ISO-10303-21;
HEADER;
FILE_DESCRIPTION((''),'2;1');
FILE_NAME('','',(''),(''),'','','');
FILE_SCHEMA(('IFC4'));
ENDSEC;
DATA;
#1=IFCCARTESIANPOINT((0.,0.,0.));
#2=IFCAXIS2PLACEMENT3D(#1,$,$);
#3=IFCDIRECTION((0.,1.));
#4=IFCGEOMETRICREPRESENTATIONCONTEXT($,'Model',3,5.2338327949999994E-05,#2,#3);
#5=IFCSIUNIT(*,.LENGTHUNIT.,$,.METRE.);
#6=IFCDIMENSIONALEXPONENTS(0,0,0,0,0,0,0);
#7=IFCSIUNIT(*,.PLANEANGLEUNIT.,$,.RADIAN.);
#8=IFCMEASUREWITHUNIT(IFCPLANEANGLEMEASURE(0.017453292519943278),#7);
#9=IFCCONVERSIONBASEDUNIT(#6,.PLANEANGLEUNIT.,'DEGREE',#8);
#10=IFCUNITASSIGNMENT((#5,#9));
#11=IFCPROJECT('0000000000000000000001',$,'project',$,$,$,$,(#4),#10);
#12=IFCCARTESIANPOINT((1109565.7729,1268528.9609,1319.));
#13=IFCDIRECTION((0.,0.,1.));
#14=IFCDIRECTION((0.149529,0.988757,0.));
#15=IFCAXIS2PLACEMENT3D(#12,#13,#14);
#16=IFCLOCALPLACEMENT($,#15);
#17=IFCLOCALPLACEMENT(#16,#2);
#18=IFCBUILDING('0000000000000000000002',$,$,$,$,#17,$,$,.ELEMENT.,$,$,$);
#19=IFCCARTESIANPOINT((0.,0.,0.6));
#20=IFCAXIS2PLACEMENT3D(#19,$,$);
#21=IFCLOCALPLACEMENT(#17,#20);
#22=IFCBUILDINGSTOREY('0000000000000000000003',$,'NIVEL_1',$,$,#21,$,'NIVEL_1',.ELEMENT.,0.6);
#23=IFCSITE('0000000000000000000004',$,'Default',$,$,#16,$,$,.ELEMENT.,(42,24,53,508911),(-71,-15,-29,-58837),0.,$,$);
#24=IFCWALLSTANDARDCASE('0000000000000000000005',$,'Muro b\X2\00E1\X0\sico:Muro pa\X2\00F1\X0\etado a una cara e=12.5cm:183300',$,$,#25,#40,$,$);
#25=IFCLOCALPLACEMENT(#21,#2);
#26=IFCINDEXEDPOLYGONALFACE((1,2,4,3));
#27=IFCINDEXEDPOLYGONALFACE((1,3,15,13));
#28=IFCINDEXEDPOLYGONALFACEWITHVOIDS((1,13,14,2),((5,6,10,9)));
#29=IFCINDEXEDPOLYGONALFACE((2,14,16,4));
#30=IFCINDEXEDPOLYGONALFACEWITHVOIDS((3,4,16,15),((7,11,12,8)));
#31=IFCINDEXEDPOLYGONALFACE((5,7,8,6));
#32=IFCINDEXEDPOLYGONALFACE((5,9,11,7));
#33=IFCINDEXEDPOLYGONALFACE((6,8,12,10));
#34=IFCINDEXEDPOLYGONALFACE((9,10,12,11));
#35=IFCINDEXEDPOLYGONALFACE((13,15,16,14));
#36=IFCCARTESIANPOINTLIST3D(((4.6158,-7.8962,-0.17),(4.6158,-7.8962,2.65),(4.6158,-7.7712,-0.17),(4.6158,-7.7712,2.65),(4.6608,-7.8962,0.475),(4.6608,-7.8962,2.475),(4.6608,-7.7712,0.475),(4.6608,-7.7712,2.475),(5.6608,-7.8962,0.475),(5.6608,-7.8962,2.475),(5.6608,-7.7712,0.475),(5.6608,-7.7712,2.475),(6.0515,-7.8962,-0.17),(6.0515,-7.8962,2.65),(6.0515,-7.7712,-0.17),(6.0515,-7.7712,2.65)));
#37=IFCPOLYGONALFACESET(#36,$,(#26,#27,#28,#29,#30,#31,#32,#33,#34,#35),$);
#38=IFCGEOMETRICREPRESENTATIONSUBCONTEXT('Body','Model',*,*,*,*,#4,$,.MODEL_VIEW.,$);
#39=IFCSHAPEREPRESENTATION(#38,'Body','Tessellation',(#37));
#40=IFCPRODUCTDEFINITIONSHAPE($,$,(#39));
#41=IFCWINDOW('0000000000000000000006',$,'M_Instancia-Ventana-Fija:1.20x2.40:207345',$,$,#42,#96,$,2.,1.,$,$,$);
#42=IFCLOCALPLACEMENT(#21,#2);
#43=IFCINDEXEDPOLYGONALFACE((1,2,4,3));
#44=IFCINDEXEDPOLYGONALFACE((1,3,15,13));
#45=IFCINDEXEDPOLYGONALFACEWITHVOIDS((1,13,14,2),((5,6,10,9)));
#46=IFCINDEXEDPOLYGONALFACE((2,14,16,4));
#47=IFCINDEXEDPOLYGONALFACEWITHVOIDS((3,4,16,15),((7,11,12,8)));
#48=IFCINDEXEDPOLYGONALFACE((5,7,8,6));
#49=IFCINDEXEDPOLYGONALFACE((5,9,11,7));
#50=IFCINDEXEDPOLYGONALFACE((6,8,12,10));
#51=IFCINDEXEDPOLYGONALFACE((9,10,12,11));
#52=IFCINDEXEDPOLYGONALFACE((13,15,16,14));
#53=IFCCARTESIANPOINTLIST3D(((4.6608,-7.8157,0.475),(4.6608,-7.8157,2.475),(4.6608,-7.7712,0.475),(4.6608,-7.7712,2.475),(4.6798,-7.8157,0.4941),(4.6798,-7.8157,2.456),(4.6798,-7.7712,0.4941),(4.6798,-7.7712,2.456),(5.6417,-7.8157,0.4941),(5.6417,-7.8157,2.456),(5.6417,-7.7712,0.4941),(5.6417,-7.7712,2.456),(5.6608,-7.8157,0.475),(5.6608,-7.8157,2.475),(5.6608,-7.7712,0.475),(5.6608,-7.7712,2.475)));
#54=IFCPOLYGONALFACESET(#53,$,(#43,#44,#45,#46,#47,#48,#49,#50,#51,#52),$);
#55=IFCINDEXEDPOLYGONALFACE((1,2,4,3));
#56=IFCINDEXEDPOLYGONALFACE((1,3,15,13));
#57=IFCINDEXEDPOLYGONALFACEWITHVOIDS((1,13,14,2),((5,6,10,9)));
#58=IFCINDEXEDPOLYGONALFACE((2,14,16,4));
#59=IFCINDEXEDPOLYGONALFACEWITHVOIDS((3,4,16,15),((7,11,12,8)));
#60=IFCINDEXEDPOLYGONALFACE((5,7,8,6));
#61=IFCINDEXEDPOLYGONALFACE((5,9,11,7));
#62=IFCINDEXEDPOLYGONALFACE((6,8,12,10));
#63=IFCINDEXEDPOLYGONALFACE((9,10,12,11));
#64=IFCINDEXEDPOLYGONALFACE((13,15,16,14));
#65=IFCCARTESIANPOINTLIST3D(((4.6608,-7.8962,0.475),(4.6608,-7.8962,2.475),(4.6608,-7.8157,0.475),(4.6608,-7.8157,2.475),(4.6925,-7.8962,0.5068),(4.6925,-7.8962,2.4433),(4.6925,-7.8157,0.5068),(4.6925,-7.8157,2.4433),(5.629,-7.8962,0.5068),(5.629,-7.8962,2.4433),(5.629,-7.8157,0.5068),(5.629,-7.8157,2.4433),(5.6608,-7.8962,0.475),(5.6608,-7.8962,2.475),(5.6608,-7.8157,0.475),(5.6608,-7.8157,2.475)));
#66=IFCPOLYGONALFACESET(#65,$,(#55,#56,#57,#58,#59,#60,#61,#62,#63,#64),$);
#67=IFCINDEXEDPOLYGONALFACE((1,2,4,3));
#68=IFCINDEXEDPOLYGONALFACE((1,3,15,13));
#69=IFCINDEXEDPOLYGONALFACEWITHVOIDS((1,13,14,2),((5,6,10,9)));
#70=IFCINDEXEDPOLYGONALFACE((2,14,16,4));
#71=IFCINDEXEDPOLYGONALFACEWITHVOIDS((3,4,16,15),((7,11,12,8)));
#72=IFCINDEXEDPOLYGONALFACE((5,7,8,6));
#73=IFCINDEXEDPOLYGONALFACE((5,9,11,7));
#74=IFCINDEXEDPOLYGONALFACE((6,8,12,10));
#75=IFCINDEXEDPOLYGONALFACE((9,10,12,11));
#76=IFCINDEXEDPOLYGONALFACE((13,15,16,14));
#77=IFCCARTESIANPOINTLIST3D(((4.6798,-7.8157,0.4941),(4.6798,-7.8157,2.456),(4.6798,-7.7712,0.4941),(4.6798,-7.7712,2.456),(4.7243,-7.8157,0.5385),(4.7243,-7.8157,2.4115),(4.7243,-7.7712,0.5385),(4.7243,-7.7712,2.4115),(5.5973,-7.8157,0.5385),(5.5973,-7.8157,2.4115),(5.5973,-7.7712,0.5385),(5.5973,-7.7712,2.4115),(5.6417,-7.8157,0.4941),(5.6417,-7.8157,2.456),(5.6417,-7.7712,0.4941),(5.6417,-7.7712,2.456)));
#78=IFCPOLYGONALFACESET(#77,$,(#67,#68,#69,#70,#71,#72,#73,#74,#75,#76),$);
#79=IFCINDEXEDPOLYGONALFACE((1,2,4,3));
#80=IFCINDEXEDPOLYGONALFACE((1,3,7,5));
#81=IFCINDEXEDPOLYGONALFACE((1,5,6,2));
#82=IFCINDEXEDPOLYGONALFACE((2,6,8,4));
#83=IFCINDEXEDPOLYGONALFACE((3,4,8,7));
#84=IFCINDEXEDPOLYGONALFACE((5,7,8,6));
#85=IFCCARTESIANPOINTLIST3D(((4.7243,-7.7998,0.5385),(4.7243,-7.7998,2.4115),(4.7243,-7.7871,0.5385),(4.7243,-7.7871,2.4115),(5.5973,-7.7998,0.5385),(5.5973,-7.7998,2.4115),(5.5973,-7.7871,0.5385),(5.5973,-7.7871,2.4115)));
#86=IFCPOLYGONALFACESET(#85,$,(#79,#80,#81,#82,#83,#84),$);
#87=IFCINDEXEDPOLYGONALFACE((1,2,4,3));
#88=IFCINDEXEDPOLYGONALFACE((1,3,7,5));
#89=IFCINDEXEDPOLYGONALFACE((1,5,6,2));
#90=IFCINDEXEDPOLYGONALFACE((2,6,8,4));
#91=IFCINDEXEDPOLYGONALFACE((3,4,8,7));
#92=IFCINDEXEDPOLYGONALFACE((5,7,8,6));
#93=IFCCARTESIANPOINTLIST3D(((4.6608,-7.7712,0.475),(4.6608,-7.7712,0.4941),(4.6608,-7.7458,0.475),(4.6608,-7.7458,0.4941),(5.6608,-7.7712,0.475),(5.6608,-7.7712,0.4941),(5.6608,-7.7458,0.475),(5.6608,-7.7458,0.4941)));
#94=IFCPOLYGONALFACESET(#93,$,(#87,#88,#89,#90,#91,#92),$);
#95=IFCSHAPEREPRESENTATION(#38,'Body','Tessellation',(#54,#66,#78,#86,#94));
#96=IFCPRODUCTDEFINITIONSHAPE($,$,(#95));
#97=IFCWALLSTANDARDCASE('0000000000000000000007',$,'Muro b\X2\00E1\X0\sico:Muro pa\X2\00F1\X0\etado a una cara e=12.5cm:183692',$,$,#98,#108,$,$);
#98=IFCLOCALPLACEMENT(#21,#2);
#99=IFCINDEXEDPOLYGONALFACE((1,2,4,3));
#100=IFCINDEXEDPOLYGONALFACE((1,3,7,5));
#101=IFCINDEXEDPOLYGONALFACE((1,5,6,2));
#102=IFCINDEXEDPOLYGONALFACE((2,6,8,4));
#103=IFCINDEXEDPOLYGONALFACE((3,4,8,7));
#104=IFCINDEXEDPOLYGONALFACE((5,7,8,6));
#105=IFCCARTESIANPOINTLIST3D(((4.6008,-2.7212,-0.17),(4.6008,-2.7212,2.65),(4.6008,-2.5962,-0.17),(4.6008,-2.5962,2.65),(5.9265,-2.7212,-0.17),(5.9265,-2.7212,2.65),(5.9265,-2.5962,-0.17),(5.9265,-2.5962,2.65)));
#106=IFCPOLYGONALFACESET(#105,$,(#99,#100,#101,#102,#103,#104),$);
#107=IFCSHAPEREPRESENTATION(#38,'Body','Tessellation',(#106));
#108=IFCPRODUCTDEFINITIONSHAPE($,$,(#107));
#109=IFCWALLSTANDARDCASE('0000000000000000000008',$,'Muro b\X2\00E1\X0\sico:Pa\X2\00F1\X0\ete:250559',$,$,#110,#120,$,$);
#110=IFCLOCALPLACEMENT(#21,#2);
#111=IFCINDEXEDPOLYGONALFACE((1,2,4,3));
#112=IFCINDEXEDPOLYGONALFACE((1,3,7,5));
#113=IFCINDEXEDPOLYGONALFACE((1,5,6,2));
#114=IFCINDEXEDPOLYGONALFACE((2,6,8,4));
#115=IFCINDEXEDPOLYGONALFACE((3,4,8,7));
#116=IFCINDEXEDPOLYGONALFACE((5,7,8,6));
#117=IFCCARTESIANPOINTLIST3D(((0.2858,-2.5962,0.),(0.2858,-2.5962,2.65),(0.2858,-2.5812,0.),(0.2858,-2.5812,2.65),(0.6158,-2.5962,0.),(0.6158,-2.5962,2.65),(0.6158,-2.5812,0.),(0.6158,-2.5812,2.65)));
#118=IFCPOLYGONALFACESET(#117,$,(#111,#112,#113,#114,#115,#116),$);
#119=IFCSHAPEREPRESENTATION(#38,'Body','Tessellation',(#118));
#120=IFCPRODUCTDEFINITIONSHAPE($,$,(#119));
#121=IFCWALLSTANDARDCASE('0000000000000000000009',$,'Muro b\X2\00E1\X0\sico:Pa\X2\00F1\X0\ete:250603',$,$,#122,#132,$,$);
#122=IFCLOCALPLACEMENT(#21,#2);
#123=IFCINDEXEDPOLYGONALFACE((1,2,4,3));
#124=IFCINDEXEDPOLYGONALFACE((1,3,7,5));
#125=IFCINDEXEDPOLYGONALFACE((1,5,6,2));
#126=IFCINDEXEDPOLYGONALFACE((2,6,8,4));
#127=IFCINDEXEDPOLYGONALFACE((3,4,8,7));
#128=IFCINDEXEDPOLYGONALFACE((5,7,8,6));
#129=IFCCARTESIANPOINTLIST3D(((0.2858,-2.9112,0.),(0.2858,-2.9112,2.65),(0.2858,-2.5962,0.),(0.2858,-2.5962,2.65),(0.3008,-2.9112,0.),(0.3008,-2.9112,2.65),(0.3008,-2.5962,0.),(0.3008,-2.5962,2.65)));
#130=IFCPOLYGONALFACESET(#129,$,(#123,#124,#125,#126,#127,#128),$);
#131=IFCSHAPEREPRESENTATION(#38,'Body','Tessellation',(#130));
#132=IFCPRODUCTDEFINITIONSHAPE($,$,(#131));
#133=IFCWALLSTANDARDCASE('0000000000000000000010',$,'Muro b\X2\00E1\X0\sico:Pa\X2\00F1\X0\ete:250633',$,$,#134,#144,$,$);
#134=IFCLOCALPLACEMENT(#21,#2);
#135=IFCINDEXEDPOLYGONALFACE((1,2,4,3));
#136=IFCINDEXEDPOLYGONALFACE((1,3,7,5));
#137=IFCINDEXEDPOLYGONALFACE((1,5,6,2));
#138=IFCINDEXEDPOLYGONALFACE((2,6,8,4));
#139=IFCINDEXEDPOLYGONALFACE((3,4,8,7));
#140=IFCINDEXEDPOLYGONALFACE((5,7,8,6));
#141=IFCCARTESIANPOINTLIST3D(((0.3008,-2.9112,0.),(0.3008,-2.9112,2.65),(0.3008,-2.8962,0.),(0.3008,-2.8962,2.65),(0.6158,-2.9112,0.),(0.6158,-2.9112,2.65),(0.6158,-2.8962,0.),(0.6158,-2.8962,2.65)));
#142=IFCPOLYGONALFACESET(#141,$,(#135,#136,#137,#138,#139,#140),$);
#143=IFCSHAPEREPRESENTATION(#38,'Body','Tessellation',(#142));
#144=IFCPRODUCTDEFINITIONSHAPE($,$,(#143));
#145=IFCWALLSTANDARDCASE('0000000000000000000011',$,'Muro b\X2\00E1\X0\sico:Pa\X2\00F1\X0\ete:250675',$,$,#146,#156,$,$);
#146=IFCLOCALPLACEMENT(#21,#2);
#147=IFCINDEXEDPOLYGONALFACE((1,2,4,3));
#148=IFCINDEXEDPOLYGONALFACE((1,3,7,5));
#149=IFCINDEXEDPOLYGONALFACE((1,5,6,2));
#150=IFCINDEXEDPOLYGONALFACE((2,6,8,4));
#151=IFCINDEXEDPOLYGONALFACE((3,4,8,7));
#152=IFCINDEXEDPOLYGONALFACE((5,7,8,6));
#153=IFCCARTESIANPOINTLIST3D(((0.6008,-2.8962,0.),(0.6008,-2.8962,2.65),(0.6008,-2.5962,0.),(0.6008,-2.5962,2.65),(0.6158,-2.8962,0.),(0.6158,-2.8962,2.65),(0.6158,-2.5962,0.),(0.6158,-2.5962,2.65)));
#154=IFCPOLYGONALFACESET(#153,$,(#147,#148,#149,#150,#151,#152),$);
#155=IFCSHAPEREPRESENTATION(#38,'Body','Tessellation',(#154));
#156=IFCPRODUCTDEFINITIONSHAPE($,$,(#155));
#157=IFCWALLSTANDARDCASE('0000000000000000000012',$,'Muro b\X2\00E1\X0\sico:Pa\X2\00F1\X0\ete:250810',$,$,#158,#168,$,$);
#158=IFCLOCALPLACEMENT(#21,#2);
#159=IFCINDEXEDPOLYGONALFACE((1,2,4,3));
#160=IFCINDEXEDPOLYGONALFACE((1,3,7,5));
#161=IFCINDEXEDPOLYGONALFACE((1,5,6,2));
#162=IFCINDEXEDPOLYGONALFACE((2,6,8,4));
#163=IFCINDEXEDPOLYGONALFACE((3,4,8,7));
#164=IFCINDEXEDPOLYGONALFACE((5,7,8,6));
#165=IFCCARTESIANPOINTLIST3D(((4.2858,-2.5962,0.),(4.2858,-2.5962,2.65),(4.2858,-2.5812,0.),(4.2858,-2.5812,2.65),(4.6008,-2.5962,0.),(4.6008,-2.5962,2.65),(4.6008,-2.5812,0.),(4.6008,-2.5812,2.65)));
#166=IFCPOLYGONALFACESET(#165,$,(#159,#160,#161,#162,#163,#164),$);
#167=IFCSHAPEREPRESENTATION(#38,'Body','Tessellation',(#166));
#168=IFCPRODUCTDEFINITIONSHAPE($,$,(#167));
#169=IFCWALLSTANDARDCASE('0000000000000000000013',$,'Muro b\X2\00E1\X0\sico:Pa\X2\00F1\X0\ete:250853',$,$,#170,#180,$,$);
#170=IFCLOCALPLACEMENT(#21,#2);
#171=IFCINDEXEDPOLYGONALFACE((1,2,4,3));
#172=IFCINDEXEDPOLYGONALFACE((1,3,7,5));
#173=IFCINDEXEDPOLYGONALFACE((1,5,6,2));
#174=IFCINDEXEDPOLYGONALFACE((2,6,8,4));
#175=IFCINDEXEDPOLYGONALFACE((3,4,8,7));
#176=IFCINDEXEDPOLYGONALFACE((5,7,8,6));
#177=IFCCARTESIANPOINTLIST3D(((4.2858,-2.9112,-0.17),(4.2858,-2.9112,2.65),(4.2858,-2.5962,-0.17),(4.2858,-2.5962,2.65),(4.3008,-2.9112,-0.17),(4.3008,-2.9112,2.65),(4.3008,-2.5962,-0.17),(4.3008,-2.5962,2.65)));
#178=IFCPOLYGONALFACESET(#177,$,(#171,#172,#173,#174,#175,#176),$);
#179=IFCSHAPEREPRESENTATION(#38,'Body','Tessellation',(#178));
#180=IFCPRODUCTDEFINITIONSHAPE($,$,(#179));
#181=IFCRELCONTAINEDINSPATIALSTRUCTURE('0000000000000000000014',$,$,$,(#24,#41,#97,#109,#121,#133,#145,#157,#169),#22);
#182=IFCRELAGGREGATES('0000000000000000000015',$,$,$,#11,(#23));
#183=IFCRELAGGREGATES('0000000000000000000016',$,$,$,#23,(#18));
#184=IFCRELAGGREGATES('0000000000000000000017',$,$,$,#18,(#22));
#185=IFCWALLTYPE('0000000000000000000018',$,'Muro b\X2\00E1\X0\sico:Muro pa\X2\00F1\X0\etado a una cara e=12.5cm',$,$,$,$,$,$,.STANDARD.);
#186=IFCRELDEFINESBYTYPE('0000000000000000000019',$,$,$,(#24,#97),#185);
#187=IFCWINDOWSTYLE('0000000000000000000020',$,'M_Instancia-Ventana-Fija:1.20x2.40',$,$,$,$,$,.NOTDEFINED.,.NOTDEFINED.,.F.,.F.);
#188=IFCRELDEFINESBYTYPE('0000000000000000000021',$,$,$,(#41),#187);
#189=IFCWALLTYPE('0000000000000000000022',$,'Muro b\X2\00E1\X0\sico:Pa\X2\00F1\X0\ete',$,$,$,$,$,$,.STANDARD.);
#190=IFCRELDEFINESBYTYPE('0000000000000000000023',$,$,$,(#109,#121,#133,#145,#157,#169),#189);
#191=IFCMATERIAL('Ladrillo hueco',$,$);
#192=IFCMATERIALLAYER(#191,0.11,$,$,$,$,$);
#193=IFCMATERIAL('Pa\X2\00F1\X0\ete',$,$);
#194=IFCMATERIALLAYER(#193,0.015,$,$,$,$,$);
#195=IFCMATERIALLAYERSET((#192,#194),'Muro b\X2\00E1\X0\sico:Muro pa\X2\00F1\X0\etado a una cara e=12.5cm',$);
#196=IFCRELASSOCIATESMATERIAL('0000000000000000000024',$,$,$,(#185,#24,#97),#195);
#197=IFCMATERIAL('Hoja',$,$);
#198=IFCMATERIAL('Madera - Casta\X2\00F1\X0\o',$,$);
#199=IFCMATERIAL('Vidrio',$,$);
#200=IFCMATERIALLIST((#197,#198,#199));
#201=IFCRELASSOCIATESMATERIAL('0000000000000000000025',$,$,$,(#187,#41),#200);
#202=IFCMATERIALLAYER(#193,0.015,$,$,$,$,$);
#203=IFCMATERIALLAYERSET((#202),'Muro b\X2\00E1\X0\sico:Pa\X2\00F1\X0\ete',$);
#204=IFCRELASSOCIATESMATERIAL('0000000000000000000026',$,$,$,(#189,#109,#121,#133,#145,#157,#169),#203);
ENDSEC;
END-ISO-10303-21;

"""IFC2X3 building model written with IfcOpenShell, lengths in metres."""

from ifc_helpers import new_model, entity, si_unit, converted_unit, direction, frame, frame_2d, origin, origin_2d_with_axis, place, context, subcontext, project, spatial, polyline, rectangle, outline, extrude, source, transform, mapped, material, material_list, layer, layer_set, layer_usage, type_object, type_shapes, element, fill, save


model = new_model("IFC2X3")

# Units and contexts
model_context = context("Model", 3, precision=5.2338327949999994e-05, world=origin(), true_north=direction((0.0, 1.0)))
body_context = subcontext(model_context, "Body", "Model", "MODEL_VIEW")
ifc_project = project(units=[si_unit("LENGTHUNIT", "METRE"), converted_unit("PLANEANGLEUNIT", "DEGREE", entity("IfcPlaneAngleMeasure", 0.017453292519943278), si_unit("PLANEANGLEUNIT", "RADIAN"), dimensions=[0, 0, 0, 0, 0, 0, 0])], contexts=[model_context])

# Site, building, storey
site_placement = place(None, frame((1109565.7729, 1268528.9609, 1319.0), z_axis=(0.0, 0.0, 1.0), x_axis=(0.149529, 0.988757, 0.0)))
site = spatial("IfcSite", under=ifc_project, at=site_placement, Name="Default", CompositionType="ELEMENT", RefLatitude=(42, 24, 53, 508911), RefLongitude=(-71, -15, -29, -58837), RefElevation=0.0)
building_placement = place(site_placement, origin())
building = spatial("IfcBuilding", under=site, at=building_placement, CompositionType="ELEMENT")
storey_placement = place(building_placement, frame((0.0, 0.0, 0.6)))
storey = spatial("IfcBuildingStorey", under=building, at=storey_placement, Name="NIVEL_1", LongName="NIVEL_1", CompositionType="ELEMENT", Elevation=0.6)

# Shared definitions
ifc_material_1 = material(Name="Pañete")
ifc_material_2 = material(Name="Ladrillo hueco")

# Shared definitions
ifc_layer_1 = layer(ifc_material_2, 0.11)
ifc_layer_2 = layer(ifc_material_1, 0.015)
ifc_layer_set_1 = layer_set([ifc_layer_1, ifc_layer_2], Name="Muro básico:Muro pañetado a una cara e=12.5cm")
wall_type_1 = type_object("IfcWallType", Name="Muro básico:Muro pañetado a una cara e=12.5cm", PredefinedType="STANDARD", material=ifc_layer_set_1)
ifc_material_3 = material(Name="Hoja")
ifc_material_4 = material(Name="Madera - Castaño")
ifc_material_5 = material(Name="Vidrio")
ifc_material_list = material_list([ifc_material_3, ifc_material_4, ifc_material_5])
window_style = type_object("IfcWindowStyle", Name="M_Instancia-Ventana-Fija:1.20x2.40", ConstructionType="NOTDEFINED", OperationType="NOTDEFINED", ParameterTakesPrecedence=False, Sizeable=False, material=ifc_material_list)
shared_shape_1 = source(origin(), body_context, "Body", "SweptSolid", [
    extrude(outline(polyline([(-1.0, -0.5), (1.0, -0.5), (1.0, 0.5), (-1.0, 0.5), (-1.0, -0.5)]), holes=[polyline([(-0.9809, -0.4809), (-0.9809, 0.481), (0.981, 0.481), (0.981, -0.4809), (-0.9809, -0.4809)])]), frame((0.5, 0.0806, 1.0), z_axis=(0.0, 1.0, 0.0), x_axis=(0.0, 0.0, -1.0)), (0.0, 0.0, 1.0), 0.0444),
    extrude(outline(polyline([(-0.5, -1.0), (0.5, -1.0), (0.5, 1.0), (-0.5, 1.0), (-0.5, -1.0)]), holes=[polyline([(-0.4683, -0.9682), (-0.4683, 0.9683), (0.4682, 0.9683), (0.4682, -0.9682), (-0.4683, -0.9682)])]), frame((0.5, 0.0, 1.0), z_axis=(0.0, 1.0, 0.0), x_axis=(1.0, 0.0, 0.0)), (0.0, 0.0, 1.0), 0.0806),
    extrude(outline(polyline([(-0.4809, -0.981), (0.4809, -0.981), (0.4809, 0.981), (-0.4809, 0.981), (-0.4809, -0.981)]), holes=[polyline([(-0.4365, -0.9365), (-0.4365, 0.9365), (0.4365, 0.9365), (0.4365, -0.9365), (-0.4365, -0.9365)])]), frame((0.5, 0.0806, 1.0), z_axis=(0.0, 1.0, 0.0), x_axis=(1.0, 0.0, 0.0)), (0.0, 0.0, 1.0), 0.0444),
    extrude(rectangle(XDim=0.0127, YDim=0.873, at=frame_2d((0.0, 0.0), x_axis=(1.0, 0.0))), frame((0.5, 0.1028, 0.0635), z_axis=(0.0, 0.0, 1.0), x_axis=(0.0, 1.0, 0.0)), (0.0, 0.0, 1.0), 1.873),
    extrude(rectangle(XDim=0.0254, YDim=1.0, at=origin_2d_with_axis()), frame((0.5, 0.1377, 0.0), z_axis=(0.0, 0.0, 1.0), x_axis=(0.0, -1.0, 0.0)), (0.0, 0.0, 1.0), 0.019),
])
type_shapes(window_style, [shared_shape_1])

# Wall, opening, window
ifc_layer_usage_1 = layer_usage(ifc_layer_set_1, "AXIS2", "POSITIVE", -0.0625)
wall_1_placement = place(storey_placement, frame((4.6158, -7.8337, -0.17)))
wall_1 = element("IfcWallStandardCase", 1, at=wall_1_placement, inside=storey, type_object=wall_type_1, material=ifc_layer_usage_1, Name="Muro básico:Muro pañetado a una cara e=12.5cm:183300", context=body_context, shape_type="SweptSolid", body=[
    extrude(rectangle(XDim=1.4357, YDim=0.125, at=frame_2d((0.7179, 0.0), x_axis=(-1.0, 0.0))), origin(), (0.0, 0.0, 1.0), 2.82),
])
opening_1_placement = place(wall_1_placement, frame((0.045, -0.0625, 0.645)))
opening_1 = element("IfcOpeningElement", 2, at=opening_1_placement, cuts=wall_1, ObjectType="Opening", context=body_context, shape_type="SweptSolid", body=[
    extrude(rectangle(XDim=2.0, YDim=1.0, at=frame_2d((1.0, 0.5), x_axis=(-1.0, 0.0))), frame((0.0, 0.0, 0.0), z_axis=(0.0, 1.0, 0.0), x_axis=(0.0, 0.0, 1.0)), (0.0, 0.0, 1.0), 0.125),
])
window_1_placement = place(opening_1_placement, origin())
window_1 = element("IfcWindow", 3, at=window_1_placement, inside=storey, type_object=window_style, material=ifc_material_list, Name="M_Instancia-Ventana-Fija:1.20x2.40:207345", OverallHeight=2.0, OverallWidth=1.0, context=body_context, shape_type="MappedRepresentation", body=[
    mapped(shared_shape_1, transform((0.0, 0.0, 0.0), scale=1.0)),
])
fill(opening_1, window_1)

# Walls
ifc_layer_usage_2 = layer_usage(ifc_layer_set_1, "AXIS2", "NEGATIVE", 0.0625)
wall_2_placement = place(storey_placement, frame((4.6008, -2.6587, -0.17)))
element("IfcWallStandardCase", 4, at=wall_2_placement, inside=storey, type_object=wall_type_1, material=ifc_layer_usage_2, Name="Muro básico:Muro pañetado a una cara e=12.5cm:183692", context=body_context, shape_type="SweptSolid", body=[
    extrude(rectangle(XDim=1.3257, YDim=0.125, at=frame_2d((0.6629, 0.0), x_axis=(-1.0, 0.0))), origin(), (0.0, 0.0, 1.0), 2.82),
])
ifc_layer_3 = layer(ifc_material_1, 0.015)
ifc_layer_set_2 = layer_set([ifc_layer_3], Name="Muro básico:Pañete")
ifc_layer_usage_3 = layer_usage(ifc_layer_set_2, "AXIS2", "POSITIVE", -0.0075)
wall_type_2 = type_object("IfcWallType", Name="Muro básico:Pañete", PredefinedType="STANDARD", material=ifc_layer_set_2)
wall_3_placement = place(storey_placement, frame((0.6158, -2.5887, 0.0), z_axis=(0.0, 0.0, 1.0), x_axis=(-1.0, 0.0, 0.0)))
element("IfcWallStandardCase", 5, at=wall_3_placement, inside=storey, type_object=wall_type_2, material=ifc_layer_usage_3, Name="Muro básico:Pañete:250559", context=body_context, shape_type="SweptSolid", body=[
    extrude(rectangle(XDim=0.33, YDim=0.015, at=frame_2d((0.165, 0.0), x_axis=(-1.0, 0.0))), origin(), (0.0, 0.0, 1.0), 2.65),
])
ifc_layer_usage_4 = layer_usage(ifc_layer_set_2, "AXIS2", "POSITIVE", -0.0075)
wall_4_placement = place(storey_placement, frame((0.2933, -2.5962, 0.0), z_axis=(0.0, 0.0, 1.0), x_axis=(0.0, -1.0, 0.0)))
element("IfcWallStandardCase", 6, at=wall_4_placement, inside=storey, type_object=wall_type_2, material=ifc_layer_usage_4, Name="Muro básico:Pañete:250603", context=body_context, shape_type="SweptSolid", body=[
    extrude(rectangle(XDim=0.315, YDim=0.015, at=frame_2d((0.1575, 0.0), x_axis=(-1.0, 0.0))), origin(), (0.0, 0.0, 1.0), 2.65),
])
ifc_layer_usage_5 = layer_usage(ifc_layer_set_2, "AXIS2", "POSITIVE", -0.0075)
wall_5_placement = place(storey_placement, frame((0.3008, -2.9037, 0.0)))
element("IfcWallStandardCase", 7, at=wall_5_placement, inside=storey, type_object=wall_type_2, material=ifc_layer_usage_5, Name="Muro básico:Pañete:250633", context=body_context, shape_type="SweptSolid", body=[
    extrude(rectangle(XDim=0.315, YDim=0.015, at=frame_2d((0.1575, 0.0), x_axis=(-1.0, 0.0))), origin(), (0.0, 0.0, 1.0), 2.65),
])
ifc_layer_usage_6 = layer_usage(ifc_layer_set_2, "AXIS2", "POSITIVE", -0.0075)
wall_6_placement = place(storey_placement, frame((0.6083, -2.8962, 0.0), z_axis=(0.0, 0.0, 1.0), x_axis=(0.0, 1.0, 0.0)))
element("IfcWallStandardCase", 8, at=wall_6_placement, inside=storey, type_object=wall_type_2, material=ifc_layer_usage_6, Name="Muro básico:Pañete:250675", context=body_context, shape_type="SweptSolid", body=[
    extrude(rectangle(XDim=0.3, YDim=0.015, at=frame_2d((0.15, 0.0), x_axis=(-1.0, 0.0))), origin(), (0.0, 0.0, 1.0), 2.65),
])
ifc_layer_usage_7 = layer_usage(ifc_layer_set_2, "AXIS2", "POSITIVE", -0.0075)
wall_7_placement = place(storey_placement, frame((4.6008, -2.5887, 0.0), z_axis=(0.0, 0.0, 1.0), x_axis=(-1.0, 0.0, 0.0)))
element("IfcWallStandardCase", 9, at=wall_7_placement, inside=storey, type_object=wall_type_2, material=ifc_layer_usage_7, Name="Muro básico:Pañete:250810", context=body_context, shape_type="SweptSolid", body=[
    extrude(rectangle(XDim=0.315, YDim=0.015, at=frame_2d((0.1575, 0.0), x_axis=(-1.0, 0.0))), origin(), (0.0, 0.0, 1.0), 2.65),
])
ifc_layer_usage_8 = layer_usage(ifc_layer_set_2, "AXIS2", "POSITIVE", -0.0075)
wall_8_placement = place(storey_placement, frame((4.2933, -2.5962, -0.17), z_axis=(0.0, 0.0, 1.0), x_axis=(0.0, -1.0, 0.0)))
element("IfcWallStandardCase", 10, at=wall_8_placement, inside=storey, type_object=wall_type_2, material=ifc_layer_usage_8, Name="Muro básico:Pañete:250853", context=body_context, shape_type="SweptSolid", body=[
    extrude(rectangle(XDim=0.315, YDim=0.015, at=frame_2d((0.1575, 0.0), x_axis=(-1.0, 0.0))), origin(), (0.0, 0.0, 1.0), 2.82),
])

save(model, "model.ifc")
